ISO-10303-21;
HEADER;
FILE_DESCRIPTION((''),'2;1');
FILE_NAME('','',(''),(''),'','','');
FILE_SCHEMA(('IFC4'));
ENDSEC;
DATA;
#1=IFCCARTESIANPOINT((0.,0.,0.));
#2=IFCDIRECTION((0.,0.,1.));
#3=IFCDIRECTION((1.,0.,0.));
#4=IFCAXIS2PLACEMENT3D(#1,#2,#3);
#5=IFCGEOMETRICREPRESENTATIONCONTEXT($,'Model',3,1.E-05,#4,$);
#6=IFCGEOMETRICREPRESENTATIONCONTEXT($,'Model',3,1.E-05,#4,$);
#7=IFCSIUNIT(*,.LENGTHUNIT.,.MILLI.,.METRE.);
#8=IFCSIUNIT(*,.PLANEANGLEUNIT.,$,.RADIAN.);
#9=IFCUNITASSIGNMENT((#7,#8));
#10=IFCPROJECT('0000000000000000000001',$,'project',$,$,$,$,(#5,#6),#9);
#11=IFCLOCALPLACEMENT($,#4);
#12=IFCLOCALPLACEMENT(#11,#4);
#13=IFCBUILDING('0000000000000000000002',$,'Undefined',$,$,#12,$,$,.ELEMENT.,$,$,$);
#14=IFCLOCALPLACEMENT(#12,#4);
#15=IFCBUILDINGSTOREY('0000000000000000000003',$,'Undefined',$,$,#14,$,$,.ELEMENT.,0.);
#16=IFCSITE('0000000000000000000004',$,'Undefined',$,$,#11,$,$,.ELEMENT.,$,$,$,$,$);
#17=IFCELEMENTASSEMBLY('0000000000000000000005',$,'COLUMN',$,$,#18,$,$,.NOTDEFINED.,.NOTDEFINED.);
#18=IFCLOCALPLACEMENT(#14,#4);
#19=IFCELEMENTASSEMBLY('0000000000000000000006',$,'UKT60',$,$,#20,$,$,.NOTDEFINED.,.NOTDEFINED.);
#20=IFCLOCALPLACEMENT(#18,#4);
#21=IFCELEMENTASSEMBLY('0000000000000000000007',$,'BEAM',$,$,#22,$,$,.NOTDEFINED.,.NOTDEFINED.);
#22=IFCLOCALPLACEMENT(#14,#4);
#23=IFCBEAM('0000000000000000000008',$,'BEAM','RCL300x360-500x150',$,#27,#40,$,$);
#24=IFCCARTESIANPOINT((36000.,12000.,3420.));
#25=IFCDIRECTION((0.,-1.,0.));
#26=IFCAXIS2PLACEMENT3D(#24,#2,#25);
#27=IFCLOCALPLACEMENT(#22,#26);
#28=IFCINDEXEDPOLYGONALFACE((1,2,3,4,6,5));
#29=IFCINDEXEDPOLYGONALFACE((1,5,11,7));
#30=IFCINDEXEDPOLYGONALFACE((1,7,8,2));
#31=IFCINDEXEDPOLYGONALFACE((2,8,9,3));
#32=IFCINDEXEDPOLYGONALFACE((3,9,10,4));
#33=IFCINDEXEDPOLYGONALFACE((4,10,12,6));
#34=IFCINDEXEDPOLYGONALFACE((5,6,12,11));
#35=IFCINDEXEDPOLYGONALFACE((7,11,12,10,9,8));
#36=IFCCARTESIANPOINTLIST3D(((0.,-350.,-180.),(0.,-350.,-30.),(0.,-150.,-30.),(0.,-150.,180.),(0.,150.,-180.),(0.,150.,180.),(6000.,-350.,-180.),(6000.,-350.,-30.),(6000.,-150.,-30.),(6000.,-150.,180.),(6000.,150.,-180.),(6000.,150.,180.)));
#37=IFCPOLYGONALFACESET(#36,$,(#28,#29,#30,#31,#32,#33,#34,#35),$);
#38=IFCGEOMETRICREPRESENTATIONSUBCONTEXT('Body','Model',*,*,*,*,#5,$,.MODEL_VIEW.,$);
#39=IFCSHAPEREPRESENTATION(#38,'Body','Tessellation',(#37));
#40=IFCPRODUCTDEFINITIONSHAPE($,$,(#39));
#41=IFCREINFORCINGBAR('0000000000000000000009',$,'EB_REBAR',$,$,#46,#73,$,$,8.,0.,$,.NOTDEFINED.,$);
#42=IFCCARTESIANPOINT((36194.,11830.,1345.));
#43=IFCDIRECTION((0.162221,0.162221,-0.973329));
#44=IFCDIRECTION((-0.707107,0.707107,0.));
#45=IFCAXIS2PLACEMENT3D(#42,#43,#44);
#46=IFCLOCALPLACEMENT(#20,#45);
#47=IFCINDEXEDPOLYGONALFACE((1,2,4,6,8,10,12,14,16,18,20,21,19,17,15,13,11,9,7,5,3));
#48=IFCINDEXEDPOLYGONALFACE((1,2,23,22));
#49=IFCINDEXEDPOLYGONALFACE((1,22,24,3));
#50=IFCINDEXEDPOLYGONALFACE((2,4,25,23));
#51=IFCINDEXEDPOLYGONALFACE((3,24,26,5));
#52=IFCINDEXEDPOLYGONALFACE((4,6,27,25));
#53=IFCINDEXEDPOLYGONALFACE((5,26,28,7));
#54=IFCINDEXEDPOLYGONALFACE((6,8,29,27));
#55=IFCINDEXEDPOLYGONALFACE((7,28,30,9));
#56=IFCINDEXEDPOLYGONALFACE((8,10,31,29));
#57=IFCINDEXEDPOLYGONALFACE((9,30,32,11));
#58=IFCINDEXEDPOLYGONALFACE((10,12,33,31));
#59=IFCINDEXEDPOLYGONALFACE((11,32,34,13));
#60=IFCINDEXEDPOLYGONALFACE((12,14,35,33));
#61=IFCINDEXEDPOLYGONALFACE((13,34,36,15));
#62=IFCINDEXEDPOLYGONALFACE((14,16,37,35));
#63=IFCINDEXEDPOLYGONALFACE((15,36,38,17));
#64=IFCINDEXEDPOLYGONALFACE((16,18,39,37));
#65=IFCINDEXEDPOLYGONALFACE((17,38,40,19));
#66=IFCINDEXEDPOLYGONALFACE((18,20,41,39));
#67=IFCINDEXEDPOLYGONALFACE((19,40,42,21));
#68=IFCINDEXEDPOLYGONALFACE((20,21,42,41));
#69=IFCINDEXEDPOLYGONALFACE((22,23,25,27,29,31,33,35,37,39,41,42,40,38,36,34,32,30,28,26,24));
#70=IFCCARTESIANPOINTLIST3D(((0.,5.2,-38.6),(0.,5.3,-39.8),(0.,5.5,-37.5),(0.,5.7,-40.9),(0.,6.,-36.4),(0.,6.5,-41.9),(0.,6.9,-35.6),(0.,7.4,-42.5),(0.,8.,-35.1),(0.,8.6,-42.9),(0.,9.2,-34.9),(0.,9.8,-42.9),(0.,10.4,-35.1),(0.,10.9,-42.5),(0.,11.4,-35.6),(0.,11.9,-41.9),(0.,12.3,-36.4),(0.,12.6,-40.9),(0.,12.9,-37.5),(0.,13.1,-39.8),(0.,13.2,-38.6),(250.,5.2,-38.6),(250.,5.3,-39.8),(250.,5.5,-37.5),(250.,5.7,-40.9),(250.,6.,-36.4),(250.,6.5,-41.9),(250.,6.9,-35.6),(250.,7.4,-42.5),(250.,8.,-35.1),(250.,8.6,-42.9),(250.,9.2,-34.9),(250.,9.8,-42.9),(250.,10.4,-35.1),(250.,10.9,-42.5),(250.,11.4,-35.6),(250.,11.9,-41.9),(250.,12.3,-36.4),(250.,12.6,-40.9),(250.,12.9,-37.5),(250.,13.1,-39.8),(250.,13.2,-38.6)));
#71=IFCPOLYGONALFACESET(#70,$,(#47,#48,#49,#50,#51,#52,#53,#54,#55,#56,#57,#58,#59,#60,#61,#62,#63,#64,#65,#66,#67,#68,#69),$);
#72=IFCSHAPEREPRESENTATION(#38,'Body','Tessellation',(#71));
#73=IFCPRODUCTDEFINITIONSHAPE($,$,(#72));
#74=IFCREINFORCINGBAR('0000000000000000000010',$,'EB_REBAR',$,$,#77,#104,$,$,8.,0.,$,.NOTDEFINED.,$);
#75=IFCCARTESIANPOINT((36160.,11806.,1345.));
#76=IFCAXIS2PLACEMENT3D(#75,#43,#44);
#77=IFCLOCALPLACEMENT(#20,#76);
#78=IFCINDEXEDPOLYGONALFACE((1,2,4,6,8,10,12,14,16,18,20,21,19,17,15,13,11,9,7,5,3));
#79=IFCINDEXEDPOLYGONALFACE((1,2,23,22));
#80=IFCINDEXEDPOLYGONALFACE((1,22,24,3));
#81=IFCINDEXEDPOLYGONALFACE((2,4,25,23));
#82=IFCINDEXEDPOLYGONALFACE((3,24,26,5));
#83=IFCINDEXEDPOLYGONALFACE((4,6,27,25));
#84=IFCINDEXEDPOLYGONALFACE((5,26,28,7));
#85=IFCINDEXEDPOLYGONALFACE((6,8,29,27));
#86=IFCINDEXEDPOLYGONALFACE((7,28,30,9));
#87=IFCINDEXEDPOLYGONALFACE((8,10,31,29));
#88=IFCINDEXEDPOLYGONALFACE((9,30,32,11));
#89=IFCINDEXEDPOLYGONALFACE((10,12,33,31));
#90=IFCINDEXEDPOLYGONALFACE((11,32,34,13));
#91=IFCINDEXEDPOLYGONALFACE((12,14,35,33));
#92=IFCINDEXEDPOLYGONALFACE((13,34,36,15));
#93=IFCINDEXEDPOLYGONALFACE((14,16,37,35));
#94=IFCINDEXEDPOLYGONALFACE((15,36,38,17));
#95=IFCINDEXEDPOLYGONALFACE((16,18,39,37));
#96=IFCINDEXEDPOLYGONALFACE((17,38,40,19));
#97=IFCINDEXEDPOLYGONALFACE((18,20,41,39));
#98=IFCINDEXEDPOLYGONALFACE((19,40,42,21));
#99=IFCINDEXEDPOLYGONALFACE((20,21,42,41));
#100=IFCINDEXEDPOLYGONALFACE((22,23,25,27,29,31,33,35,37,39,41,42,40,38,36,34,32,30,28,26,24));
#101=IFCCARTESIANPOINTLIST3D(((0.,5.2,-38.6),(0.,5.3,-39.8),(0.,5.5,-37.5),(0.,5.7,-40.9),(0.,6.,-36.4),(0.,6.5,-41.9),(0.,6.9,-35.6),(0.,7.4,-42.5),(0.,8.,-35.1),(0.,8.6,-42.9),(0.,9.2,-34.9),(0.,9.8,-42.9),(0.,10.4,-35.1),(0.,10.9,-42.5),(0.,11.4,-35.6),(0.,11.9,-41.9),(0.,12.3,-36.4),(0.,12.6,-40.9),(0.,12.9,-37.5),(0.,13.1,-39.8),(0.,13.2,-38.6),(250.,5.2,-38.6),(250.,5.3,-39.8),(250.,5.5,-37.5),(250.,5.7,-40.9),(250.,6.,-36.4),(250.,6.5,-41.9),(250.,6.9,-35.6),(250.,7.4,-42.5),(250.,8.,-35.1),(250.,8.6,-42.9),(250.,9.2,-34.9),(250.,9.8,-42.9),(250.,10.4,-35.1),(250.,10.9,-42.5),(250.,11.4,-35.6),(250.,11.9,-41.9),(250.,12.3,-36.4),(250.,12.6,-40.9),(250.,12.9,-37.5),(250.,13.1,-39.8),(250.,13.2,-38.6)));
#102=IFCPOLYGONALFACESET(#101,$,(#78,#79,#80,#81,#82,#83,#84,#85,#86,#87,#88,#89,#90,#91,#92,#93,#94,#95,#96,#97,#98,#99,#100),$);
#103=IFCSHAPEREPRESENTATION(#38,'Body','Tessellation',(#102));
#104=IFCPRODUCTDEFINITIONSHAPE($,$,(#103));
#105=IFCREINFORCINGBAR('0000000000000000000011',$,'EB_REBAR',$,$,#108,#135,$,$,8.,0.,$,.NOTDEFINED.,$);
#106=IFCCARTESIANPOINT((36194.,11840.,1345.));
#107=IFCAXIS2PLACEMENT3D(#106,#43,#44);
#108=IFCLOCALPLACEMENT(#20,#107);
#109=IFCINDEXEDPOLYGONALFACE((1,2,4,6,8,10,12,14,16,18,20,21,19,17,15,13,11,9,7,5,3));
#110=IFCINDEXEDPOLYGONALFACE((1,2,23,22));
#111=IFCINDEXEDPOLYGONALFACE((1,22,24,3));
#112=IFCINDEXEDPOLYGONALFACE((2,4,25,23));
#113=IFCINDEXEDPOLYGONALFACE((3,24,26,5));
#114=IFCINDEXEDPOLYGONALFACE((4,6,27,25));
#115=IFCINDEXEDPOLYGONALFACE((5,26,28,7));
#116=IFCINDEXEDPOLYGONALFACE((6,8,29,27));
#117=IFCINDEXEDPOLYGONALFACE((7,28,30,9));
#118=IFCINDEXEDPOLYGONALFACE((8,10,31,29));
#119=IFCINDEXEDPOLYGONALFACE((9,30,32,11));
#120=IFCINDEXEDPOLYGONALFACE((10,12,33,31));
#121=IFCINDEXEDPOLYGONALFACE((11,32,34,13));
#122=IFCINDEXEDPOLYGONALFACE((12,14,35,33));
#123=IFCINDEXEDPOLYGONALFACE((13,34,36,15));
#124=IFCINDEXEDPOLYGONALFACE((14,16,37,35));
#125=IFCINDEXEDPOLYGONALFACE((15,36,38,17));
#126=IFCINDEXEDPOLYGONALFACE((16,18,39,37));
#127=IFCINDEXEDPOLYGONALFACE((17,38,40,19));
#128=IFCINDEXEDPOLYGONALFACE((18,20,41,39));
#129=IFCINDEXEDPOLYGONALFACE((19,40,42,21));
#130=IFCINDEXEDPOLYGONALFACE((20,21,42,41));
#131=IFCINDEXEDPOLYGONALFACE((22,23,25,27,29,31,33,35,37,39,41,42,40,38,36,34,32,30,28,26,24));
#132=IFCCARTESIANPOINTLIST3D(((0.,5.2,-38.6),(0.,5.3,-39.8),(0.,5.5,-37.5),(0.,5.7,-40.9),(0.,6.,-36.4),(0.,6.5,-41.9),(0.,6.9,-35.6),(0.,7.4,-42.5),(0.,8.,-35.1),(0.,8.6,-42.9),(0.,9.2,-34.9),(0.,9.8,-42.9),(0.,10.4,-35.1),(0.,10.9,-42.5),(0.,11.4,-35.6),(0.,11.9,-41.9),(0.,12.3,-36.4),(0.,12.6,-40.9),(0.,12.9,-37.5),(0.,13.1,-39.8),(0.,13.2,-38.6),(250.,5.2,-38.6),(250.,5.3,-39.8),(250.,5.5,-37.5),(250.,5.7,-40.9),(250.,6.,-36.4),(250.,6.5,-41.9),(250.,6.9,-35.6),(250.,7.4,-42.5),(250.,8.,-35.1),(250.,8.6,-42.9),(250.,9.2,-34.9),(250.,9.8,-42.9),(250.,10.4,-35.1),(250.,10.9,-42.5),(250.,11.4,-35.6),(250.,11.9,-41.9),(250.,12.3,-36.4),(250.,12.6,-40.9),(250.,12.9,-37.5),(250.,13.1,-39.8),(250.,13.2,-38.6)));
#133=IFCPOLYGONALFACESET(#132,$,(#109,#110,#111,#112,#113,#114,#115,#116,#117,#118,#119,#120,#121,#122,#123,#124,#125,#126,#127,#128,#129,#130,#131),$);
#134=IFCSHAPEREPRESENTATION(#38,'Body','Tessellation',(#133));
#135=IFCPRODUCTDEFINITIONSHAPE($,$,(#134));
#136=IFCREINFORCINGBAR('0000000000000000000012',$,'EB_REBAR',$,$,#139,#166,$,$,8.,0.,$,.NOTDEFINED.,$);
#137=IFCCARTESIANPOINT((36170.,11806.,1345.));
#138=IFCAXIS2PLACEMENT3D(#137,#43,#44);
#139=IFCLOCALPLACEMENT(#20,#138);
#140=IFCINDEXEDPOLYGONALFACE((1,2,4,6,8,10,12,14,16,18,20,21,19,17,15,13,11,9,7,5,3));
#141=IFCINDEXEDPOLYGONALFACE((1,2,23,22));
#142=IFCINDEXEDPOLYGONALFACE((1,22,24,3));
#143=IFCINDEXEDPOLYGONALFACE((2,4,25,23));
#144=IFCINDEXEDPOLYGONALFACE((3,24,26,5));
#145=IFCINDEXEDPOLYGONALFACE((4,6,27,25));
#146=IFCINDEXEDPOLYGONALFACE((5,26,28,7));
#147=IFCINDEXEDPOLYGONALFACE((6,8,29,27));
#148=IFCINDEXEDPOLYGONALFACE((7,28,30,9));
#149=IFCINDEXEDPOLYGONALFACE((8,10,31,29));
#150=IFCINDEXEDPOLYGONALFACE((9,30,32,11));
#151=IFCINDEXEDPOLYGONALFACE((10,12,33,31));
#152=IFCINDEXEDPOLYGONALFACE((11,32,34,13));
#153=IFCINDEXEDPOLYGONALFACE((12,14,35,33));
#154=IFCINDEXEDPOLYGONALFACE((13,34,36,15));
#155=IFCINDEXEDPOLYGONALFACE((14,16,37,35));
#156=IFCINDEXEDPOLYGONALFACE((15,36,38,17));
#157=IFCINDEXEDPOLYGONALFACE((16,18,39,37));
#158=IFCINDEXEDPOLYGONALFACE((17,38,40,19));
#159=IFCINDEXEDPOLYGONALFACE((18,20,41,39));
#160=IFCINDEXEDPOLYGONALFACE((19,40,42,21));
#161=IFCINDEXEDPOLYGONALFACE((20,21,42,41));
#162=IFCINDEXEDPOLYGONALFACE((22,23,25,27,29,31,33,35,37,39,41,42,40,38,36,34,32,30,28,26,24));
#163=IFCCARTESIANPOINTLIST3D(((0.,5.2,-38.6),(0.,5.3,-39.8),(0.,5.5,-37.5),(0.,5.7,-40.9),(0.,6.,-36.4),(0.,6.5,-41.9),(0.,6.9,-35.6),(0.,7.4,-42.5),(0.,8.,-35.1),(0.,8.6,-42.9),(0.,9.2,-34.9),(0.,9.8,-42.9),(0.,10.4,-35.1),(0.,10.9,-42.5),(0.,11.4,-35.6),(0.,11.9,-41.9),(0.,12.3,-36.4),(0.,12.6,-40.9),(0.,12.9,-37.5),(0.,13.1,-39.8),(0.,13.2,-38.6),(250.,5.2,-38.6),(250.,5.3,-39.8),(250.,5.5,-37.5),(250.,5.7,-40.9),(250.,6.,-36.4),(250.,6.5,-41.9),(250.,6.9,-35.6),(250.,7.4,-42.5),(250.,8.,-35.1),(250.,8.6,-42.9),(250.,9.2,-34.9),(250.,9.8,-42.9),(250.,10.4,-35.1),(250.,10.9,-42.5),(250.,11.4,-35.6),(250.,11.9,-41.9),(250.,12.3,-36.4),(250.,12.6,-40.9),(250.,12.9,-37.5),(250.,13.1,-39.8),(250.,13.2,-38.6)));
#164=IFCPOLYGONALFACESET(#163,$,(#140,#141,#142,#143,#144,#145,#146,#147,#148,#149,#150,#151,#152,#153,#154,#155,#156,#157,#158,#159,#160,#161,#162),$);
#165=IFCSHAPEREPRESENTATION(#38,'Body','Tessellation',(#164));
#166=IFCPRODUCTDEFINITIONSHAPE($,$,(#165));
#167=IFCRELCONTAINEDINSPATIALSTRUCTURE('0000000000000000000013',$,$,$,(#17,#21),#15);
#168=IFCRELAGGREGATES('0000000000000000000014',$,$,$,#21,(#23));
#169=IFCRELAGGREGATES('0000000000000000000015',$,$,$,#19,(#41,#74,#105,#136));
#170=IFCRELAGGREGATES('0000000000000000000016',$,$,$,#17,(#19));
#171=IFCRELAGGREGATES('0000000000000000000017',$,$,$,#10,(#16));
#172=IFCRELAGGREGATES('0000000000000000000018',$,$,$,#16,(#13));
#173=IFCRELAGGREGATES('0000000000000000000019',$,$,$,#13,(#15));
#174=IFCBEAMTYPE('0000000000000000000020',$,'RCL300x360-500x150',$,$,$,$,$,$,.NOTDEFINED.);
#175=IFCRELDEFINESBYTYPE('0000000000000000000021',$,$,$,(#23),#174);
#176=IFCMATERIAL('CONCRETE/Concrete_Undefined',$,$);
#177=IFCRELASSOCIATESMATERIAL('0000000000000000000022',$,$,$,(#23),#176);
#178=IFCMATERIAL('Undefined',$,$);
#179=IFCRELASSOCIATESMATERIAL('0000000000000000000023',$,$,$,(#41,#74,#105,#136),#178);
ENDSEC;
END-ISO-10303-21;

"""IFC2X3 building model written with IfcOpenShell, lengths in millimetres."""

from ifc_helpers import new_model, entity, si_unit, frame, origin_with_axes, place, context, subcontext, project, spatial, polyline, outline, extrude, source, transform, mapped, material, type_object, element, aggregate, save


model = new_model("IFC2X3")

# Units and contexts
model_context_1 = context("Model", 3, precision=1e-05, world=origin_with_axes())
model_context_2 = context("Model", 3, precision=1e-05, world=origin_with_axes())
body_context = subcontext(model_context_1, "Body", "Model", "MODEL_VIEW")
ifc_project = project(units=[si_unit("LENGTHUNIT", "METRE", prefix="MILLI"), si_unit("PLANEANGLEUNIT", "RADIAN")], contexts=[model_context_1, model_context_2])

# Site, building, storey
site_placement = place(None, origin_with_axes())
site = spatial("IfcSite", under=ifc_project, at=site_placement, Name="Undefined", CompositionType="ELEMENT")
building_placement = place(site_placement, origin_with_axes())
building = spatial("IfcBuilding", under=site, at=building_placement, Name="Undefined", CompositionType="ELEMENT")
storey_placement = place(building_placement, origin_with_axes())
storey = spatial("IfcBuildingStorey", under=building, at=storey_placement, Name="Undefined", CompositionType="ELEMENT", Elevation=0.0)

# Element assemblies
assembly_1_placement = place(storey_placement, origin_with_axes())
assembly_1 = element("IfcElementAssembly", 1, at=assembly_1_placement, inside=storey, Name="COLUMN", AssemblyPlace="NOTDEFINED", PredefinedType="NOTDEFINED")
assembly_2_placement = place(assembly_1_placement, origin_with_axes())
assembly_2 = element("IfcElementAssembly", 2, at=assembly_2_placement, Name="UKT60", AssemblyPlace="NOTDEFINED", PredefinedType="NOTDEFINED")

# Element assembly, beam
assembly_3_placement = place(storey_placement, origin_with_axes())
assembly_3 = element("IfcElementAssembly", 3, at=assembly_3_placement, inside=storey, Name="BEAM", AssemblyPlace="NOTDEFINED", PredefinedType="NOTDEFINED")
ifc_material_1 = material(Name="CONCRETE/Concrete_Undefined")
beam_type_1 = type_object("IfcBeamType", Name="RCL300x360-500x150", PredefinedType="NOTDEFINED")
beam_1_placement = place(assembly_3_placement, frame((36000.0, 12000.0, 3420.0), z_axis=(0.0, 0.0, 1.0), x_axis=(0.0, -1.0, 0.0)))
beam_1 = element("IfcBeam", 4, at=beam_1_placement, type_object=beam_type_1, material=ifc_material_1, Name="BEAM", Description="RCL300x360-500x150", context=body_context, shape_type="SweptSolid", body=[
    extrude(outline(polyline([(350.0, -180.0), (-150.0, -180.0), (-150.0, 180.0), (150.0, 180.0), (150.0, -30.0), (350.0, -30.0), (350.0, -180.0)])), frame((6000.0, 0.0, 0.0), z_axis=(-1.0, 0.0, 0.0), x_axis=(0.0, -1.0, 0.0)), (0.0, 0.0, 1.0), 6000.0),
])
aggregate(assembly_3, [beam_1])

# Reinforcing bars
ifc_material_2 = material(Name="Undefined")
shared_shape_1 = source(origin_with_axes(), body_context, "Body", "AdvancedSweptSolid", [
    entity("IfcSweptDiskSolid", entity("IfcTrimmedCurve", entity("IfcLine", entity("IfcCartesianPoint", [0.0, 0.0, 0.0]), entity("IfcVector", entity("IfcDirection", [1.0, 0.0, 0.0]), 1.0)), [entity("IfcParameterValue", 0.0)], [entity("IfcParameterValue", 250.0)], True, "PARAMETER"), 4.0, None, 0.0, 250.0),
])
reinforcing_bar_1_placement = place(assembly_2_placement, frame((36194.0, 11830.0, 1345.0), z_axis=(0.162221, 0.162221, -0.973329), x_axis=(-0.707107, 0.707107, 0.0)))
reinforcing_bar_1 = element("IfcReinforcingBar", 5, at=reinforcing_bar_1_placement, material=ifc_material_2, Name="EB_REBAR", BarRole="NOTDEFINED", CrossSectionArea=0.0, NominalDiameter=8.0, context=body_context, shape_type="MappedRepresentation", body=[
    mapped(shared_shape_1, transform((0.0, 9.2, -38.9))),
])
shared_shape_2 = source(origin_with_axes(), body_context, "Body", "AdvancedSweptSolid", [
    entity("IfcSweptDiskSolid", entity("IfcTrimmedCurve", entity("IfcLine", entity("IfcCartesianPoint", [0.0, 0.0, 0.0]), entity("IfcVector", entity("IfcDirection", [1.0, 0.0, 0.0]), 1.0)), [entity("IfcParameterValue", 0.0)], [entity("IfcParameterValue", 250.0)], True, "PARAMETER"), 4.0, None, 0.0, 250.0),
])
reinforcing_bar_2_placement = place(assembly_2_placement, frame((36160.0, 11806.0, 1345.0), z_axis=(0.162221, 0.162221, -0.973329), x_axis=(-0.707107, 0.707107, 0.0)))
reinforcing_bar_2 = element("IfcReinforcingBar", 6, at=reinforcing_bar_2_placement, material=ifc_material_2, Name="EB_REBAR", BarRole="NOTDEFINED", CrossSectionArea=0.0, NominalDiameter=8.0, context=body_context, shape_type="MappedRepresentation", body=[
    mapped(shared_shape_2, transform((0.0, 9.2, -38.9))),
])
shared_shape_3 = source(origin_with_axes(), body_context, "Body", "AdvancedSweptSolid", [
    entity("IfcSweptDiskSolid", entity("IfcTrimmedCurve", entity("IfcLine", entity("IfcCartesianPoint", [0.0, 0.0, 0.0]), entity("IfcVector", entity("IfcDirection", [1.0, 0.0, 0.0]), 1.0)), [entity("IfcParameterValue", 0.0)], [entity("IfcParameterValue", 250.0)], True, "PARAMETER"), 4.0, None, 0.0, 250.0),
])
reinforcing_bar_3_placement = place(assembly_2_placement, frame((36194.0, 11840.0, 1345.0), z_axis=(0.162221, 0.162221, -0.973329), x_axis=(-0.707107, 0.707107, 0.0)))
reinforcing_bar_3 = element("IfcReinforcingBar", 7, at=reinforcing_bar_3_placement, material=ifc_material_2, Name="EB_REBAR", BarRole="NOTDEFINED", CrossSectionArea=0.0, NominalDiameter=8.0, context=body_context, shape_type="MappedRepresentation", body=[
    mapped(shared_shape_3, transform((0.0, 9.2, -38.9))),
])
shared_shape_4 = source(origin_with_axes(), body_context, "Body", "AdvancedSweptSolid", [
    entity("IfcSweptDiskSolid", entity("IfcTrimmedCurve", entity("IfcLine", entity("IfcCartesianPoint", [0.0, 0.0, 0.0]), entity("IfcVector", entity("IfcDirection", [1.0, 0.0, 0.0]), 1.0)), [entity("IfcParameterValue", 0.0)], [entity("IfcParameterValue", 250.0)], True, "PARAMETER"), 4.0, None, 0.0, 250.0),
])
reinforcing_bar_4_placement = place(assembly_2_placement, frame((36170.0, 11806.0, 1345.0), z_axis=(0.162221, 0.162221, -0.973329), x_axis=(-0.707107, 0.707107, 0.0)))
reinforcing_bar_4 = element("IfcReinforcingBar", 8, at=reinforcing_bar_4_placement, material=ifc_material_2, Name="EB_REBAR", BarRole="NOTDEFINED", CrossSectionArea=0.0, NominalDiameter=8.0, context=body_context, shape_type="MappedRepresentation", body=[
    mapped(shared_shape_4, transform((0.0, 9.2, -38.9))),
])
aggregate(assembly_2, [reinforcing_bar_1, reinforcing_bar_2, reinforcing_bar_3, reinforcing_bar_4])
aggregate(assembly_1, [assembly_2])

save(model, "model.ifc")
